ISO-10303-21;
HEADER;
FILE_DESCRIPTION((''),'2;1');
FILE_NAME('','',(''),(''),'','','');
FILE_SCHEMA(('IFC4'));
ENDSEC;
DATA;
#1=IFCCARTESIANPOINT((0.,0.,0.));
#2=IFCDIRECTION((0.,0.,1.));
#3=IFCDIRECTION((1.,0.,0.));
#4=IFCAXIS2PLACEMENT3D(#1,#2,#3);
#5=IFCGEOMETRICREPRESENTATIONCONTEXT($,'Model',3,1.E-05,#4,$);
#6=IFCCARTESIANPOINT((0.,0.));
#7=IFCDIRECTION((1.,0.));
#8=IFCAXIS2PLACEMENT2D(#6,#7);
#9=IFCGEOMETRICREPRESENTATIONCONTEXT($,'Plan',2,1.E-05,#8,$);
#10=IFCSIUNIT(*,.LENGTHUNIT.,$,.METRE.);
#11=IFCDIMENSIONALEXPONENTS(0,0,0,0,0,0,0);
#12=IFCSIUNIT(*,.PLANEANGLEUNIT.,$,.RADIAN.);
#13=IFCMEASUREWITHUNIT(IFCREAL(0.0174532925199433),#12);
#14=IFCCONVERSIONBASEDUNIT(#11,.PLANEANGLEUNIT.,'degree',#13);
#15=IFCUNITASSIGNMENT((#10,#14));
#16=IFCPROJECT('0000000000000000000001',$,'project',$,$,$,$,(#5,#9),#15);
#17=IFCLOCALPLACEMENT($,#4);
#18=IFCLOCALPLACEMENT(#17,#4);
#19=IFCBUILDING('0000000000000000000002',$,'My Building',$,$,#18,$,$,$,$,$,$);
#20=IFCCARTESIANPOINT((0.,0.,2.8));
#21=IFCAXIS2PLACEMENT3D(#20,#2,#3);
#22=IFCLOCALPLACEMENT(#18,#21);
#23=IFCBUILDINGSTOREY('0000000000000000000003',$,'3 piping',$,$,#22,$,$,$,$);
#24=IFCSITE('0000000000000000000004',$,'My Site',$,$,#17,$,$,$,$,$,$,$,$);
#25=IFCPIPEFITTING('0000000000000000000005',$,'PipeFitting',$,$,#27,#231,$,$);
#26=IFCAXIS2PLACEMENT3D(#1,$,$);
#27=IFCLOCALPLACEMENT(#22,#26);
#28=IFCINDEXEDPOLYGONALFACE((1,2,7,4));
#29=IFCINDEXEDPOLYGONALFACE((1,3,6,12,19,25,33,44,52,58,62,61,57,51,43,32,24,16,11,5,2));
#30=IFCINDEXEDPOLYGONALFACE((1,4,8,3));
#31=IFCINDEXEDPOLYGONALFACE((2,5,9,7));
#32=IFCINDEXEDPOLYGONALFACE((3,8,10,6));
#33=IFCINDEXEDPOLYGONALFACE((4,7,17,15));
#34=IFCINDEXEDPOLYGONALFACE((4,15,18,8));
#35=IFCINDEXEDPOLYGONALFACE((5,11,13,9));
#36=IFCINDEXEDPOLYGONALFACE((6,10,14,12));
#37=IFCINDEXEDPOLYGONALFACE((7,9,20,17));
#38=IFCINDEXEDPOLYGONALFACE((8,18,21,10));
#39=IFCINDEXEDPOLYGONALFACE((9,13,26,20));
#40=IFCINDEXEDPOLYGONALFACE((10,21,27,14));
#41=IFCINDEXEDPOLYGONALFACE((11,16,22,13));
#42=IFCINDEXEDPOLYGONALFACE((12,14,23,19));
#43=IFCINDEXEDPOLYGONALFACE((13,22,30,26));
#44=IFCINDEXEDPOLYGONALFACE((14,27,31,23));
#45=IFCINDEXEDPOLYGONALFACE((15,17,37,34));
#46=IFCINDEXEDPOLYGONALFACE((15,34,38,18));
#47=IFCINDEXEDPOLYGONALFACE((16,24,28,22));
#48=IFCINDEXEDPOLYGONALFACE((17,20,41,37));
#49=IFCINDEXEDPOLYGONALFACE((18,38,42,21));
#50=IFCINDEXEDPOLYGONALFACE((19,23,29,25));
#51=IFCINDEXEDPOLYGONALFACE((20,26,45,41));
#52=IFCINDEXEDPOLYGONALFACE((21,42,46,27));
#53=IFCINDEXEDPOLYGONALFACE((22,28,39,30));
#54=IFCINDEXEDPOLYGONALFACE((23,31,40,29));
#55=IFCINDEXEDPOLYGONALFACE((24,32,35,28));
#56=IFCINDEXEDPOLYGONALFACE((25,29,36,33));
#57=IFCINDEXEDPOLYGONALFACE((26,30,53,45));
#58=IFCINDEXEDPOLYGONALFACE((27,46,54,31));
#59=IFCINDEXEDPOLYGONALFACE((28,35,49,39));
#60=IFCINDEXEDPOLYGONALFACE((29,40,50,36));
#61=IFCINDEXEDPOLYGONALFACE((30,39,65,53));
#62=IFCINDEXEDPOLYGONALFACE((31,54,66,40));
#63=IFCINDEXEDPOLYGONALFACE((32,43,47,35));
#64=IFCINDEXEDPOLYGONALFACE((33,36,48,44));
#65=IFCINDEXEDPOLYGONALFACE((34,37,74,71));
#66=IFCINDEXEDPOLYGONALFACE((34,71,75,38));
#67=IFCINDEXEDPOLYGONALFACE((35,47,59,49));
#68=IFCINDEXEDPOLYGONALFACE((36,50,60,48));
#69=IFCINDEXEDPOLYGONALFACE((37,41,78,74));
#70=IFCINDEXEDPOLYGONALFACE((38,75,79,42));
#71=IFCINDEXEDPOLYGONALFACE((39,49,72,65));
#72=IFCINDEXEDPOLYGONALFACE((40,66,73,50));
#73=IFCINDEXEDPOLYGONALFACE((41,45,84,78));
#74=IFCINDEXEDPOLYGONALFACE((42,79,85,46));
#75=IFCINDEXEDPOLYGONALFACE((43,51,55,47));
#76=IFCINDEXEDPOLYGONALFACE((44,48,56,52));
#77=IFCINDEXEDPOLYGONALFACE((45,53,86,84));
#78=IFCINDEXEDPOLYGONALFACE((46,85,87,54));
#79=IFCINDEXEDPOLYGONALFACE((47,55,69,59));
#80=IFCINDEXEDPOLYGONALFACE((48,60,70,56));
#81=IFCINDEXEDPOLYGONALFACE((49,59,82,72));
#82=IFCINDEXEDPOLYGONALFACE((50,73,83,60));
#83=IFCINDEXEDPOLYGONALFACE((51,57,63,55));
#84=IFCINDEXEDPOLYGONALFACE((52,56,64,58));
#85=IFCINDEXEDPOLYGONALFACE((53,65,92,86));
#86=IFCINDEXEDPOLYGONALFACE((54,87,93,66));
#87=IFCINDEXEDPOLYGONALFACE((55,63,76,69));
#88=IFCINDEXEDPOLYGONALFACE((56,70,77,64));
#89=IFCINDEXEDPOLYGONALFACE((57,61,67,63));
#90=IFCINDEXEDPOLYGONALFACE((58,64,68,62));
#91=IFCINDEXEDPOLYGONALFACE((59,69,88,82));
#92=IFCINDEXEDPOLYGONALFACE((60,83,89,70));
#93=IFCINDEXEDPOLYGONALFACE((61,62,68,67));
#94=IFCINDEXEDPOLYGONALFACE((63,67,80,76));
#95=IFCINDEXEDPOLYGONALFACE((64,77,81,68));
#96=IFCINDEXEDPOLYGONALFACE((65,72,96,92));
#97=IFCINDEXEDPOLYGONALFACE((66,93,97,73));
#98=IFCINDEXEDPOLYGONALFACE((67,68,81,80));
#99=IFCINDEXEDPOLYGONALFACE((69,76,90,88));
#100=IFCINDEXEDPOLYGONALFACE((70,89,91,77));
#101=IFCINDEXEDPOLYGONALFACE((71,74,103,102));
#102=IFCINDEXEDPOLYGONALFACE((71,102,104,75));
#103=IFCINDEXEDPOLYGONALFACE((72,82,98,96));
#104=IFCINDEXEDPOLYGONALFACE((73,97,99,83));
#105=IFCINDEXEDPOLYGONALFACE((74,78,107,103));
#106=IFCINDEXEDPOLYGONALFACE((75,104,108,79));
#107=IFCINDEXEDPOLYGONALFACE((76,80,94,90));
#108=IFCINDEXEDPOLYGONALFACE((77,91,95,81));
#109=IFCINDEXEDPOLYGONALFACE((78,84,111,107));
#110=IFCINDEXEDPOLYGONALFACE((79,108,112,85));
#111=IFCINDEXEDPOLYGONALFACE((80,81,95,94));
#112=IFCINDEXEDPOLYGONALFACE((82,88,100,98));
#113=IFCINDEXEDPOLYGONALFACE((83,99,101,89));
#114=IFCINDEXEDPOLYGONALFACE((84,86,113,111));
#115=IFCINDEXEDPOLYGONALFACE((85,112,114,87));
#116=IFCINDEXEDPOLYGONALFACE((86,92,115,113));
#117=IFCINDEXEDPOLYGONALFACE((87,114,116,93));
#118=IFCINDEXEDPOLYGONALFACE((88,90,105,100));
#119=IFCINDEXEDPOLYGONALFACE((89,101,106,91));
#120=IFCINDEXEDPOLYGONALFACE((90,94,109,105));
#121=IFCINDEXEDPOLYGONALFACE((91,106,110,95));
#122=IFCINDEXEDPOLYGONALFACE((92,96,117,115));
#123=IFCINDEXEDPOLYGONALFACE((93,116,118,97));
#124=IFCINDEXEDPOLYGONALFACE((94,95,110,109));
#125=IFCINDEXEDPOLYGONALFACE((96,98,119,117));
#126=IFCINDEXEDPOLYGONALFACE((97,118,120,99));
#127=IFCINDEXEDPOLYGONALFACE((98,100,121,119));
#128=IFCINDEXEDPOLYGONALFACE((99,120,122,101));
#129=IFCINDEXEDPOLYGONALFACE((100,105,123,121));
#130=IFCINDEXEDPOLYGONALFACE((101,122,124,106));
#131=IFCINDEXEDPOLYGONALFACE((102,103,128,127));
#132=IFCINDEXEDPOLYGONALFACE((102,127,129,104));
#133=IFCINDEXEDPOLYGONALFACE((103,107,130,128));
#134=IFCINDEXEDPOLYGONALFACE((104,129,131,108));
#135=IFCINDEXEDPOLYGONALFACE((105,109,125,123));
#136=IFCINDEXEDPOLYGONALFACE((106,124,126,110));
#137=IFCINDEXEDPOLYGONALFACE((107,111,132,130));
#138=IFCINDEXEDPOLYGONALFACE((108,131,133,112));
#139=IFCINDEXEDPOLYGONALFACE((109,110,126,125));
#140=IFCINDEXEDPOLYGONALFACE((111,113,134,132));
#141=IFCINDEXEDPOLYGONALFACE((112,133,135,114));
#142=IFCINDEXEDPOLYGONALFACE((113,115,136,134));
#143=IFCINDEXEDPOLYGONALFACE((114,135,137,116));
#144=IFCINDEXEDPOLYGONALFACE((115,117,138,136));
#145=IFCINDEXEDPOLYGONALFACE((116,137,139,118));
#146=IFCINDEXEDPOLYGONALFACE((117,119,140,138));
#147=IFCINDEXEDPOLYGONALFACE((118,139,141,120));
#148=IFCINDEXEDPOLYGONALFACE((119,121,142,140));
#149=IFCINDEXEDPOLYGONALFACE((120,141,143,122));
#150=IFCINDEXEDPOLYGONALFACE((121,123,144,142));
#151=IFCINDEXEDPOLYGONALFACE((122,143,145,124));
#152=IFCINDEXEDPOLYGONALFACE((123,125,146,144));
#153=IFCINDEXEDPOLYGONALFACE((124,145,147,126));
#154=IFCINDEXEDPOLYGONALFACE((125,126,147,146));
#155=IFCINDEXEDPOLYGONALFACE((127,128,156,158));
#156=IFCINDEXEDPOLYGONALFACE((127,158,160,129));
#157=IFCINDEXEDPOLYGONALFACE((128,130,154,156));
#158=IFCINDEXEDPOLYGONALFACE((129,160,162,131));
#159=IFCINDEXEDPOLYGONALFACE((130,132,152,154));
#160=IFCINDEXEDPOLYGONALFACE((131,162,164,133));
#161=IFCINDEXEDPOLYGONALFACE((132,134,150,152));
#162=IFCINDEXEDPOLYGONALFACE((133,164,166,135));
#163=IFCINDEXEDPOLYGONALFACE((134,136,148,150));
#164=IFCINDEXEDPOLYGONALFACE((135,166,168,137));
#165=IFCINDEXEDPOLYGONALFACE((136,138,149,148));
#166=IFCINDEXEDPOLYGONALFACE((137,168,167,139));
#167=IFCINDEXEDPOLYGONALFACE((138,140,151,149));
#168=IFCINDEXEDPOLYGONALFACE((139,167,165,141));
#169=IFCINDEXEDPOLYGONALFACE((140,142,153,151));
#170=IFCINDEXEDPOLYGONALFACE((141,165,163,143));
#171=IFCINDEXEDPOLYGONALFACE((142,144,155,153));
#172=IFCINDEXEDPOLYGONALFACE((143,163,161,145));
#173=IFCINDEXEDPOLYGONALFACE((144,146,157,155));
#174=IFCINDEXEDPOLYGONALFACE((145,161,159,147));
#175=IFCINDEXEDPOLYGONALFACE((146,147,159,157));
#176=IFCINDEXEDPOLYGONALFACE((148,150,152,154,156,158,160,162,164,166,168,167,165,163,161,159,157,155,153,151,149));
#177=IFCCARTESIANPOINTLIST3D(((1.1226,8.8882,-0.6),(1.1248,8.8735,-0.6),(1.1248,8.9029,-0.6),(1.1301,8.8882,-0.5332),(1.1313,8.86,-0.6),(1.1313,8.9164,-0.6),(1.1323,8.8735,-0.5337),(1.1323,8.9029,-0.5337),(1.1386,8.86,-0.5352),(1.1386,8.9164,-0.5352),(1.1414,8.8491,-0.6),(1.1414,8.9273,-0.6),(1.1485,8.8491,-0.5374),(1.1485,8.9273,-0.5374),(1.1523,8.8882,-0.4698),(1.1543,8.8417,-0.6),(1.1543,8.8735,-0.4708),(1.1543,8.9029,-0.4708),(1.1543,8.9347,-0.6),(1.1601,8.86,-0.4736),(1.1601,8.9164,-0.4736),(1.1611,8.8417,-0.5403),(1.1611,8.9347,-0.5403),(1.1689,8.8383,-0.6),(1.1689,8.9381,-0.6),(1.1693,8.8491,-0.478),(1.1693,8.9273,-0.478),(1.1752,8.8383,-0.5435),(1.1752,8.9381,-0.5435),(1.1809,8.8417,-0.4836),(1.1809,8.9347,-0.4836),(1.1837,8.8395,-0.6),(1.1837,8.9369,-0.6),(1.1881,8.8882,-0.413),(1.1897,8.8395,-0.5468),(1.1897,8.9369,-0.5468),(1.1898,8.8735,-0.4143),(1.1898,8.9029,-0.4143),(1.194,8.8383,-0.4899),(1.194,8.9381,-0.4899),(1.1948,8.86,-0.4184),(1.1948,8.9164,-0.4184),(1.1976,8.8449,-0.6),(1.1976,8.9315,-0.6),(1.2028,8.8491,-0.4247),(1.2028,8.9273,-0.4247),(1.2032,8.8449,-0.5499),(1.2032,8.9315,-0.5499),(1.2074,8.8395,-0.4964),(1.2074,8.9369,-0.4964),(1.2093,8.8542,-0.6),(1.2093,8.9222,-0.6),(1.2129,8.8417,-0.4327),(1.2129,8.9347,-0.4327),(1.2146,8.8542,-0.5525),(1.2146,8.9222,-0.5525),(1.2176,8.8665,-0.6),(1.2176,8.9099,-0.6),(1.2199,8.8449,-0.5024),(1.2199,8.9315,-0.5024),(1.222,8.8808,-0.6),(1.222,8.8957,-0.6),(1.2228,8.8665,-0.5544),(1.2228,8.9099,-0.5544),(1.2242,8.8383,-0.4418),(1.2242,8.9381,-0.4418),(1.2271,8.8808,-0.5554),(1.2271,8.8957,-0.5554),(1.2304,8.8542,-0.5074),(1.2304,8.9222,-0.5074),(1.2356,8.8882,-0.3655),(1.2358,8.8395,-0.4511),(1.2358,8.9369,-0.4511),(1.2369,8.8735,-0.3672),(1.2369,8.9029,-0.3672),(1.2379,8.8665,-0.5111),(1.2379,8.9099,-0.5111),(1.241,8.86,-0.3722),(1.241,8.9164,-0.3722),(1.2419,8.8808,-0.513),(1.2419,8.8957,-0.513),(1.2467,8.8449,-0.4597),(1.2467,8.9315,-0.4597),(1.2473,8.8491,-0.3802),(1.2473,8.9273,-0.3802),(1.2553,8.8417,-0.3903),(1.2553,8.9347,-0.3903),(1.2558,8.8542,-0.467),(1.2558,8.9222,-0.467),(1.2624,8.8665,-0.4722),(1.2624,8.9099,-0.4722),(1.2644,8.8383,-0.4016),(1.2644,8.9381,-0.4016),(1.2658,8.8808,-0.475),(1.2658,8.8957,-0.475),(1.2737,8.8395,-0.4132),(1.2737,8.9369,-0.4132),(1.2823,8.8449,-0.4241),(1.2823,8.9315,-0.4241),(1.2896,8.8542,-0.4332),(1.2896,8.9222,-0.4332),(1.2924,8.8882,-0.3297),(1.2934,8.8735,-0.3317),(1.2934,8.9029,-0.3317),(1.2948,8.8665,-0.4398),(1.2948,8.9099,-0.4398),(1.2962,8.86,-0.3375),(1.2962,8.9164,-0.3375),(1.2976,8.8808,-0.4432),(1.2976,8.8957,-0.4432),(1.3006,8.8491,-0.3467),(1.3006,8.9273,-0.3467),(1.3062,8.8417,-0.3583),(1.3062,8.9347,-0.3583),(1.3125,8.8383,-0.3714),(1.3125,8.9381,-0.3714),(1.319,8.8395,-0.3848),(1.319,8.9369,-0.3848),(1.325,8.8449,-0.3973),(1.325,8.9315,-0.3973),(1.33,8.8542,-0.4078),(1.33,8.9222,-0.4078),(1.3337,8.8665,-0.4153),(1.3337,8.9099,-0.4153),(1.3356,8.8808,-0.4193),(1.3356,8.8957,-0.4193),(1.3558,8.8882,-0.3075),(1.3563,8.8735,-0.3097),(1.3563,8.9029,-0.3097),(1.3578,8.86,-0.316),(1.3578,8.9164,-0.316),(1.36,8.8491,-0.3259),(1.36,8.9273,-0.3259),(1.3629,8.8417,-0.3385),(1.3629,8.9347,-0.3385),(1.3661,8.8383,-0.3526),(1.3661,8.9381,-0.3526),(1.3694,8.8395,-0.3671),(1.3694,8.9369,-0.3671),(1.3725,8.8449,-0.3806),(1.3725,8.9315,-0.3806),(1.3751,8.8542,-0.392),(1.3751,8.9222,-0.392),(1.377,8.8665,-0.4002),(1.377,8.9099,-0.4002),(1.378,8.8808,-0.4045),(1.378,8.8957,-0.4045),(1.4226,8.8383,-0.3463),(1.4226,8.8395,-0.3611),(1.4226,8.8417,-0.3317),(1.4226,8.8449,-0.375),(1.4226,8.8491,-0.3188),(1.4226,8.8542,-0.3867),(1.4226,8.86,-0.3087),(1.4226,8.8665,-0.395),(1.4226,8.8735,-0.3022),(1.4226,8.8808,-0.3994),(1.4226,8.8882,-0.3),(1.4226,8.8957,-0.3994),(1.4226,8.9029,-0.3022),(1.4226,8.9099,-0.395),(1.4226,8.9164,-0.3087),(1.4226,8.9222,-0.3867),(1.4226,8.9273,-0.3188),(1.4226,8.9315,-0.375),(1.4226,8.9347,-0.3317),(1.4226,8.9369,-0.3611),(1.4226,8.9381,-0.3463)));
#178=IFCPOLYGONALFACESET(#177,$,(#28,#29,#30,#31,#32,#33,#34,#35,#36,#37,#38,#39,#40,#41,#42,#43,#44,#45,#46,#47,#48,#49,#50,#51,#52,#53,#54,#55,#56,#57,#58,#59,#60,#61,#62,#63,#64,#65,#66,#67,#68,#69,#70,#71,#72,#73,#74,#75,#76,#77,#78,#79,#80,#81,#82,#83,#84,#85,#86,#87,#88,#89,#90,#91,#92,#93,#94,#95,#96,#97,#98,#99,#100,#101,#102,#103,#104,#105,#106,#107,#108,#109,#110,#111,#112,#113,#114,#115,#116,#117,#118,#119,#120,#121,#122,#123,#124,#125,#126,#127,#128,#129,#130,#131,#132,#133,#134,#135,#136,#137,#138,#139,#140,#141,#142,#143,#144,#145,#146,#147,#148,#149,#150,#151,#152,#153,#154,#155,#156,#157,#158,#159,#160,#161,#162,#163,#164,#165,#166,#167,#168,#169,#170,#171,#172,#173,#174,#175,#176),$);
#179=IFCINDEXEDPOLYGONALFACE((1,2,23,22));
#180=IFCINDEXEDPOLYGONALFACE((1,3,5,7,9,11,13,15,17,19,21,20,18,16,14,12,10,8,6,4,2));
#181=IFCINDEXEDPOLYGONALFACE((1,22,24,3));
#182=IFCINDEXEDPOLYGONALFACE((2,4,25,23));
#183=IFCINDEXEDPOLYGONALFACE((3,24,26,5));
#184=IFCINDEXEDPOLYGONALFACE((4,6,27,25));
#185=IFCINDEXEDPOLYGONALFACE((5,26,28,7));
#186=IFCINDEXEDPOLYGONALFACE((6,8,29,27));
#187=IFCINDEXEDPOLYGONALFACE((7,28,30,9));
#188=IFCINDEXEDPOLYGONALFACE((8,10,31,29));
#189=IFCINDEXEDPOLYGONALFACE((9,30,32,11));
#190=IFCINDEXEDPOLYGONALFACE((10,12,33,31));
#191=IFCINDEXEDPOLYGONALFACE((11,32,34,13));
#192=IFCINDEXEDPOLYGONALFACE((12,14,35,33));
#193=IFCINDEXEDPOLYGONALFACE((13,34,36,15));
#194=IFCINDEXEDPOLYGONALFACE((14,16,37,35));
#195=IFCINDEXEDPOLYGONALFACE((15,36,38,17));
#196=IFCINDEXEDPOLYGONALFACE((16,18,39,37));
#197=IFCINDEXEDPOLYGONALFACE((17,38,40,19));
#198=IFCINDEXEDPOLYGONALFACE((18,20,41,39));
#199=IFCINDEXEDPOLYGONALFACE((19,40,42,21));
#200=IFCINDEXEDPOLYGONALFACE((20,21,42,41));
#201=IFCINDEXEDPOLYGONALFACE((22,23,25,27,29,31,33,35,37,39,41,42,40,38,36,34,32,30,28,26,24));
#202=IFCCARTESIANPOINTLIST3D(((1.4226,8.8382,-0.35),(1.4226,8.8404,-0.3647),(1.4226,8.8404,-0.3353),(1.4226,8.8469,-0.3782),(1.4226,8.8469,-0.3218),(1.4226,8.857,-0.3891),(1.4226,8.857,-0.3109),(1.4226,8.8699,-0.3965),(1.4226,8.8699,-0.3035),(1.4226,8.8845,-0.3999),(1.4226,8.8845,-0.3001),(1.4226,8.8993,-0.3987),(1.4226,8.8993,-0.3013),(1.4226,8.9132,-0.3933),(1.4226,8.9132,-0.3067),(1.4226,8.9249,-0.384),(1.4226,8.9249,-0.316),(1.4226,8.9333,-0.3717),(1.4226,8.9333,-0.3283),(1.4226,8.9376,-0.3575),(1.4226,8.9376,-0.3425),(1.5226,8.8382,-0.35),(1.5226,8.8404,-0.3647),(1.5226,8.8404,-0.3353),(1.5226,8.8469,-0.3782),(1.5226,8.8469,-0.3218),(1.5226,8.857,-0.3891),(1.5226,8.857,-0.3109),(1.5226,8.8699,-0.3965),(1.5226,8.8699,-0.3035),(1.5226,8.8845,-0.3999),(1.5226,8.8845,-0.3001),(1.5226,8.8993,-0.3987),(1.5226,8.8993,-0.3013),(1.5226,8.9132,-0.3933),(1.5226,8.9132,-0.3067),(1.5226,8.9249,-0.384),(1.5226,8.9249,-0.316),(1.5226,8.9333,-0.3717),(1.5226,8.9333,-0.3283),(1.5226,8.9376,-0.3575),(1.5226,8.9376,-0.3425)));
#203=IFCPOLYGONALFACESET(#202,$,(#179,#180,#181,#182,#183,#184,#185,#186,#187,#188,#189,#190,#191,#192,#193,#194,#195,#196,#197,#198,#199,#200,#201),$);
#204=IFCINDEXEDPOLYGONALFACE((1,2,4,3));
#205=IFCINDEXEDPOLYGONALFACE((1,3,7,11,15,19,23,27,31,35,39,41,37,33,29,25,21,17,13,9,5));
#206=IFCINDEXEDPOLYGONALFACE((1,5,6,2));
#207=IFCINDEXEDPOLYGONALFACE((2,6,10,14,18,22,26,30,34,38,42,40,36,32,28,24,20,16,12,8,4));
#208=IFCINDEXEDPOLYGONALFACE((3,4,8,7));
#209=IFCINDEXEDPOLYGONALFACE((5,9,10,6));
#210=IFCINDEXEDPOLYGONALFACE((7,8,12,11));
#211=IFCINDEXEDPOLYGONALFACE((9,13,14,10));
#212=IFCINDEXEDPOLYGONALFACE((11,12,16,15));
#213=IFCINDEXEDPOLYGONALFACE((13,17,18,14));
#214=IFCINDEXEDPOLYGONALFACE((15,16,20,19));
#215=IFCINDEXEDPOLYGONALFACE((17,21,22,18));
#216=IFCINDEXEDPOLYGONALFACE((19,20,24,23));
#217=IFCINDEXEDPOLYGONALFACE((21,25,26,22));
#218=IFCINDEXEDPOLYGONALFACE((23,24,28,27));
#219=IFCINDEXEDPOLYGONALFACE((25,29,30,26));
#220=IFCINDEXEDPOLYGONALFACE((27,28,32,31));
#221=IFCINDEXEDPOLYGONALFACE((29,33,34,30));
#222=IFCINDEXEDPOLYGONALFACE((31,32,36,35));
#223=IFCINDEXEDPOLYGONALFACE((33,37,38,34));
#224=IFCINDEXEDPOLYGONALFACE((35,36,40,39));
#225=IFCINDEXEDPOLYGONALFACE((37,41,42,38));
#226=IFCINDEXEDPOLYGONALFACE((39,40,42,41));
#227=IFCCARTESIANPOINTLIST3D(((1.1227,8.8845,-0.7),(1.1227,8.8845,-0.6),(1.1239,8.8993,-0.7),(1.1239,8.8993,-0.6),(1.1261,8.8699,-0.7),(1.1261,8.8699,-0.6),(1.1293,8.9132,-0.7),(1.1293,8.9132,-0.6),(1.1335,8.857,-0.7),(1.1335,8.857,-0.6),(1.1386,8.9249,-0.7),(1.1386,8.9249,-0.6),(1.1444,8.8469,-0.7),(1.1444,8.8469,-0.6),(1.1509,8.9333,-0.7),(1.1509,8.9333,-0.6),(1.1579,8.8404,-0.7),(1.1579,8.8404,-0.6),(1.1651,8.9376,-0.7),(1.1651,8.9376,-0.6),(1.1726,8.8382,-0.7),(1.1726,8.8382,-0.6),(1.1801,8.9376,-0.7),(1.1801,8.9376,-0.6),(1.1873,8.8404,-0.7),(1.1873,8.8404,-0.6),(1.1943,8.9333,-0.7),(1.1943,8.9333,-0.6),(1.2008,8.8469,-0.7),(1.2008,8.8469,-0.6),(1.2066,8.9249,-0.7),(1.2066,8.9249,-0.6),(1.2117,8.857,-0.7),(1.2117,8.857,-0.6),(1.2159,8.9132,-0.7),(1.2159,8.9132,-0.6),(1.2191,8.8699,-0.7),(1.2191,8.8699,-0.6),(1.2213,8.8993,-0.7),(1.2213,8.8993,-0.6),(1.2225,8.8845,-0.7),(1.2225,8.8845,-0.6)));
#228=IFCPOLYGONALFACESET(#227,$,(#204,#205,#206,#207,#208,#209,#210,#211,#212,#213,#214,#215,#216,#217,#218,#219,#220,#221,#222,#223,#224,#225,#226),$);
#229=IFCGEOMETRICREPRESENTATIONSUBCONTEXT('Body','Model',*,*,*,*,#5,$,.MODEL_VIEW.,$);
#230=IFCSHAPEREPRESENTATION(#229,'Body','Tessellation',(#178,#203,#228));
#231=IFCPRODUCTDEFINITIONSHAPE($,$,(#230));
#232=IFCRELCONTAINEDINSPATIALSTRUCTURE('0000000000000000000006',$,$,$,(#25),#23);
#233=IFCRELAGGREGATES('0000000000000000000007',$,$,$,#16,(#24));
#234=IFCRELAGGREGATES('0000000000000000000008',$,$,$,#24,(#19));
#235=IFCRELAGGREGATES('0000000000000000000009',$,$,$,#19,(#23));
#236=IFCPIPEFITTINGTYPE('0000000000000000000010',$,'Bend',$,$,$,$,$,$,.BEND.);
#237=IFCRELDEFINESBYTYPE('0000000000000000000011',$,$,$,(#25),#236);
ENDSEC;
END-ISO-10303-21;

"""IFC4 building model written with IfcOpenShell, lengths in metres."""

from ifc_helpers import new_model, entity, si_unit, converted_unit, frame, origin_with_axes, origin_2d_with_axis, place, context, subcontext, project, spatial, circle, extrude, source, transform, mapped, type_object, type_shapes, element, save


model = new_model("IFC4")

# Units and contexts
model_context = context("Model", 3, precision=1e-05, world=origin_with_axes())
plan_context = context("Plan", 2, precision=1e-05, world=origin_2d_with_axis())
body_context = subcontext(model_context, "Body", "Model", "MODEL_VIEW")
ifc_project = project(units=[si_unit("LENGTHUNIT", "METRE"), converted_unit("PLANEANGLEUNIT", "degree", entity("IfcReal", 0.0174532925199433), si_unit("PLANEANGLEUNIT", "RADIAN"), dimensions=[0, 0, 0, 0, 0, 0, 0])], contexts=[model_context, plan_context])

# Site, building, storey
site_placement = place(None, origin_with_axes())
site = spatial("IfcSite", under=ifc_project, at=site_placement, Name="My Site")
building_placement = place(site_placement, origin_with_axes())
building = spatial("IfcBuilding", under=site, at=building_placement, Name="My Building")
storey_placement = place(building_placement, frame((0.0, 0.0, 2.8), z_axis=(0.0, 0.0, 1.0), x_axis=(1.0, 0.0, 0.0)))
storey = spatial("IfcBuildingStorey", under=building, at=storey_placement, Name="3 piping")

# Pipe fitting
pipe_fitting_type_1 = type_object("IfcPipeFittingType", Name="Bend", PredefinedType="BEND")
shared_shape = source(origin_with_axes(), body_context, "Body", "SolidModel", [
    entity("IfcSweptDiskSolid", entity("IfcIndexedPolyCurve", entity("IfcCartesianPointList3D", [[0.0, 0.0, 0.1], [0.0, -0.0732, 0.2768], [0.0, -0.25, 0.35]]), [entity("IfcArcIndex", [1, 2, 3])]), 0.05),
    extrude(circle(Radius=0.05), origin_with_axes(), (0.0, 0.0, 1.0), 0.1),
    extrude(circle(Radius=0.05), frame((0.0, -0.25, 0.35), z_axis=(0.0, -1.0, 0.0), x_axis=(1.0, 0.0, 0.0)), (0.0, 0.0, 1.0), 0.1),
])
type_shapes(pipe_fitting_type_1, [shared_shape])
for number, where, z_axis, x_axis, name in (
    (1, (1.5226, 8.8882, -0.35), (-1.0, 0.0, 0.0), (0.0, -1.0, 0.0), "PipeFitting"),
):
    element("IfcPipeFitting", number, at=place(storey_placement, frame(where, z_axis=z_axis, x_axis=x_axis)), inside=storey, type_object=pipe_fitting_type_1, Name=name, context=body_context, shape_type="MappedRepresentation", body=[
        mapped(shared_shape, transform((0.0, 0.0, 0.0), x_axis=(1.0, 0.0, 0.0), y_axis=(0.0, 1.0, 0.0), z_axis=(0.0, 0.0, 1.0), scale=1.0)),
    ])

save(model, "model.ifc")
